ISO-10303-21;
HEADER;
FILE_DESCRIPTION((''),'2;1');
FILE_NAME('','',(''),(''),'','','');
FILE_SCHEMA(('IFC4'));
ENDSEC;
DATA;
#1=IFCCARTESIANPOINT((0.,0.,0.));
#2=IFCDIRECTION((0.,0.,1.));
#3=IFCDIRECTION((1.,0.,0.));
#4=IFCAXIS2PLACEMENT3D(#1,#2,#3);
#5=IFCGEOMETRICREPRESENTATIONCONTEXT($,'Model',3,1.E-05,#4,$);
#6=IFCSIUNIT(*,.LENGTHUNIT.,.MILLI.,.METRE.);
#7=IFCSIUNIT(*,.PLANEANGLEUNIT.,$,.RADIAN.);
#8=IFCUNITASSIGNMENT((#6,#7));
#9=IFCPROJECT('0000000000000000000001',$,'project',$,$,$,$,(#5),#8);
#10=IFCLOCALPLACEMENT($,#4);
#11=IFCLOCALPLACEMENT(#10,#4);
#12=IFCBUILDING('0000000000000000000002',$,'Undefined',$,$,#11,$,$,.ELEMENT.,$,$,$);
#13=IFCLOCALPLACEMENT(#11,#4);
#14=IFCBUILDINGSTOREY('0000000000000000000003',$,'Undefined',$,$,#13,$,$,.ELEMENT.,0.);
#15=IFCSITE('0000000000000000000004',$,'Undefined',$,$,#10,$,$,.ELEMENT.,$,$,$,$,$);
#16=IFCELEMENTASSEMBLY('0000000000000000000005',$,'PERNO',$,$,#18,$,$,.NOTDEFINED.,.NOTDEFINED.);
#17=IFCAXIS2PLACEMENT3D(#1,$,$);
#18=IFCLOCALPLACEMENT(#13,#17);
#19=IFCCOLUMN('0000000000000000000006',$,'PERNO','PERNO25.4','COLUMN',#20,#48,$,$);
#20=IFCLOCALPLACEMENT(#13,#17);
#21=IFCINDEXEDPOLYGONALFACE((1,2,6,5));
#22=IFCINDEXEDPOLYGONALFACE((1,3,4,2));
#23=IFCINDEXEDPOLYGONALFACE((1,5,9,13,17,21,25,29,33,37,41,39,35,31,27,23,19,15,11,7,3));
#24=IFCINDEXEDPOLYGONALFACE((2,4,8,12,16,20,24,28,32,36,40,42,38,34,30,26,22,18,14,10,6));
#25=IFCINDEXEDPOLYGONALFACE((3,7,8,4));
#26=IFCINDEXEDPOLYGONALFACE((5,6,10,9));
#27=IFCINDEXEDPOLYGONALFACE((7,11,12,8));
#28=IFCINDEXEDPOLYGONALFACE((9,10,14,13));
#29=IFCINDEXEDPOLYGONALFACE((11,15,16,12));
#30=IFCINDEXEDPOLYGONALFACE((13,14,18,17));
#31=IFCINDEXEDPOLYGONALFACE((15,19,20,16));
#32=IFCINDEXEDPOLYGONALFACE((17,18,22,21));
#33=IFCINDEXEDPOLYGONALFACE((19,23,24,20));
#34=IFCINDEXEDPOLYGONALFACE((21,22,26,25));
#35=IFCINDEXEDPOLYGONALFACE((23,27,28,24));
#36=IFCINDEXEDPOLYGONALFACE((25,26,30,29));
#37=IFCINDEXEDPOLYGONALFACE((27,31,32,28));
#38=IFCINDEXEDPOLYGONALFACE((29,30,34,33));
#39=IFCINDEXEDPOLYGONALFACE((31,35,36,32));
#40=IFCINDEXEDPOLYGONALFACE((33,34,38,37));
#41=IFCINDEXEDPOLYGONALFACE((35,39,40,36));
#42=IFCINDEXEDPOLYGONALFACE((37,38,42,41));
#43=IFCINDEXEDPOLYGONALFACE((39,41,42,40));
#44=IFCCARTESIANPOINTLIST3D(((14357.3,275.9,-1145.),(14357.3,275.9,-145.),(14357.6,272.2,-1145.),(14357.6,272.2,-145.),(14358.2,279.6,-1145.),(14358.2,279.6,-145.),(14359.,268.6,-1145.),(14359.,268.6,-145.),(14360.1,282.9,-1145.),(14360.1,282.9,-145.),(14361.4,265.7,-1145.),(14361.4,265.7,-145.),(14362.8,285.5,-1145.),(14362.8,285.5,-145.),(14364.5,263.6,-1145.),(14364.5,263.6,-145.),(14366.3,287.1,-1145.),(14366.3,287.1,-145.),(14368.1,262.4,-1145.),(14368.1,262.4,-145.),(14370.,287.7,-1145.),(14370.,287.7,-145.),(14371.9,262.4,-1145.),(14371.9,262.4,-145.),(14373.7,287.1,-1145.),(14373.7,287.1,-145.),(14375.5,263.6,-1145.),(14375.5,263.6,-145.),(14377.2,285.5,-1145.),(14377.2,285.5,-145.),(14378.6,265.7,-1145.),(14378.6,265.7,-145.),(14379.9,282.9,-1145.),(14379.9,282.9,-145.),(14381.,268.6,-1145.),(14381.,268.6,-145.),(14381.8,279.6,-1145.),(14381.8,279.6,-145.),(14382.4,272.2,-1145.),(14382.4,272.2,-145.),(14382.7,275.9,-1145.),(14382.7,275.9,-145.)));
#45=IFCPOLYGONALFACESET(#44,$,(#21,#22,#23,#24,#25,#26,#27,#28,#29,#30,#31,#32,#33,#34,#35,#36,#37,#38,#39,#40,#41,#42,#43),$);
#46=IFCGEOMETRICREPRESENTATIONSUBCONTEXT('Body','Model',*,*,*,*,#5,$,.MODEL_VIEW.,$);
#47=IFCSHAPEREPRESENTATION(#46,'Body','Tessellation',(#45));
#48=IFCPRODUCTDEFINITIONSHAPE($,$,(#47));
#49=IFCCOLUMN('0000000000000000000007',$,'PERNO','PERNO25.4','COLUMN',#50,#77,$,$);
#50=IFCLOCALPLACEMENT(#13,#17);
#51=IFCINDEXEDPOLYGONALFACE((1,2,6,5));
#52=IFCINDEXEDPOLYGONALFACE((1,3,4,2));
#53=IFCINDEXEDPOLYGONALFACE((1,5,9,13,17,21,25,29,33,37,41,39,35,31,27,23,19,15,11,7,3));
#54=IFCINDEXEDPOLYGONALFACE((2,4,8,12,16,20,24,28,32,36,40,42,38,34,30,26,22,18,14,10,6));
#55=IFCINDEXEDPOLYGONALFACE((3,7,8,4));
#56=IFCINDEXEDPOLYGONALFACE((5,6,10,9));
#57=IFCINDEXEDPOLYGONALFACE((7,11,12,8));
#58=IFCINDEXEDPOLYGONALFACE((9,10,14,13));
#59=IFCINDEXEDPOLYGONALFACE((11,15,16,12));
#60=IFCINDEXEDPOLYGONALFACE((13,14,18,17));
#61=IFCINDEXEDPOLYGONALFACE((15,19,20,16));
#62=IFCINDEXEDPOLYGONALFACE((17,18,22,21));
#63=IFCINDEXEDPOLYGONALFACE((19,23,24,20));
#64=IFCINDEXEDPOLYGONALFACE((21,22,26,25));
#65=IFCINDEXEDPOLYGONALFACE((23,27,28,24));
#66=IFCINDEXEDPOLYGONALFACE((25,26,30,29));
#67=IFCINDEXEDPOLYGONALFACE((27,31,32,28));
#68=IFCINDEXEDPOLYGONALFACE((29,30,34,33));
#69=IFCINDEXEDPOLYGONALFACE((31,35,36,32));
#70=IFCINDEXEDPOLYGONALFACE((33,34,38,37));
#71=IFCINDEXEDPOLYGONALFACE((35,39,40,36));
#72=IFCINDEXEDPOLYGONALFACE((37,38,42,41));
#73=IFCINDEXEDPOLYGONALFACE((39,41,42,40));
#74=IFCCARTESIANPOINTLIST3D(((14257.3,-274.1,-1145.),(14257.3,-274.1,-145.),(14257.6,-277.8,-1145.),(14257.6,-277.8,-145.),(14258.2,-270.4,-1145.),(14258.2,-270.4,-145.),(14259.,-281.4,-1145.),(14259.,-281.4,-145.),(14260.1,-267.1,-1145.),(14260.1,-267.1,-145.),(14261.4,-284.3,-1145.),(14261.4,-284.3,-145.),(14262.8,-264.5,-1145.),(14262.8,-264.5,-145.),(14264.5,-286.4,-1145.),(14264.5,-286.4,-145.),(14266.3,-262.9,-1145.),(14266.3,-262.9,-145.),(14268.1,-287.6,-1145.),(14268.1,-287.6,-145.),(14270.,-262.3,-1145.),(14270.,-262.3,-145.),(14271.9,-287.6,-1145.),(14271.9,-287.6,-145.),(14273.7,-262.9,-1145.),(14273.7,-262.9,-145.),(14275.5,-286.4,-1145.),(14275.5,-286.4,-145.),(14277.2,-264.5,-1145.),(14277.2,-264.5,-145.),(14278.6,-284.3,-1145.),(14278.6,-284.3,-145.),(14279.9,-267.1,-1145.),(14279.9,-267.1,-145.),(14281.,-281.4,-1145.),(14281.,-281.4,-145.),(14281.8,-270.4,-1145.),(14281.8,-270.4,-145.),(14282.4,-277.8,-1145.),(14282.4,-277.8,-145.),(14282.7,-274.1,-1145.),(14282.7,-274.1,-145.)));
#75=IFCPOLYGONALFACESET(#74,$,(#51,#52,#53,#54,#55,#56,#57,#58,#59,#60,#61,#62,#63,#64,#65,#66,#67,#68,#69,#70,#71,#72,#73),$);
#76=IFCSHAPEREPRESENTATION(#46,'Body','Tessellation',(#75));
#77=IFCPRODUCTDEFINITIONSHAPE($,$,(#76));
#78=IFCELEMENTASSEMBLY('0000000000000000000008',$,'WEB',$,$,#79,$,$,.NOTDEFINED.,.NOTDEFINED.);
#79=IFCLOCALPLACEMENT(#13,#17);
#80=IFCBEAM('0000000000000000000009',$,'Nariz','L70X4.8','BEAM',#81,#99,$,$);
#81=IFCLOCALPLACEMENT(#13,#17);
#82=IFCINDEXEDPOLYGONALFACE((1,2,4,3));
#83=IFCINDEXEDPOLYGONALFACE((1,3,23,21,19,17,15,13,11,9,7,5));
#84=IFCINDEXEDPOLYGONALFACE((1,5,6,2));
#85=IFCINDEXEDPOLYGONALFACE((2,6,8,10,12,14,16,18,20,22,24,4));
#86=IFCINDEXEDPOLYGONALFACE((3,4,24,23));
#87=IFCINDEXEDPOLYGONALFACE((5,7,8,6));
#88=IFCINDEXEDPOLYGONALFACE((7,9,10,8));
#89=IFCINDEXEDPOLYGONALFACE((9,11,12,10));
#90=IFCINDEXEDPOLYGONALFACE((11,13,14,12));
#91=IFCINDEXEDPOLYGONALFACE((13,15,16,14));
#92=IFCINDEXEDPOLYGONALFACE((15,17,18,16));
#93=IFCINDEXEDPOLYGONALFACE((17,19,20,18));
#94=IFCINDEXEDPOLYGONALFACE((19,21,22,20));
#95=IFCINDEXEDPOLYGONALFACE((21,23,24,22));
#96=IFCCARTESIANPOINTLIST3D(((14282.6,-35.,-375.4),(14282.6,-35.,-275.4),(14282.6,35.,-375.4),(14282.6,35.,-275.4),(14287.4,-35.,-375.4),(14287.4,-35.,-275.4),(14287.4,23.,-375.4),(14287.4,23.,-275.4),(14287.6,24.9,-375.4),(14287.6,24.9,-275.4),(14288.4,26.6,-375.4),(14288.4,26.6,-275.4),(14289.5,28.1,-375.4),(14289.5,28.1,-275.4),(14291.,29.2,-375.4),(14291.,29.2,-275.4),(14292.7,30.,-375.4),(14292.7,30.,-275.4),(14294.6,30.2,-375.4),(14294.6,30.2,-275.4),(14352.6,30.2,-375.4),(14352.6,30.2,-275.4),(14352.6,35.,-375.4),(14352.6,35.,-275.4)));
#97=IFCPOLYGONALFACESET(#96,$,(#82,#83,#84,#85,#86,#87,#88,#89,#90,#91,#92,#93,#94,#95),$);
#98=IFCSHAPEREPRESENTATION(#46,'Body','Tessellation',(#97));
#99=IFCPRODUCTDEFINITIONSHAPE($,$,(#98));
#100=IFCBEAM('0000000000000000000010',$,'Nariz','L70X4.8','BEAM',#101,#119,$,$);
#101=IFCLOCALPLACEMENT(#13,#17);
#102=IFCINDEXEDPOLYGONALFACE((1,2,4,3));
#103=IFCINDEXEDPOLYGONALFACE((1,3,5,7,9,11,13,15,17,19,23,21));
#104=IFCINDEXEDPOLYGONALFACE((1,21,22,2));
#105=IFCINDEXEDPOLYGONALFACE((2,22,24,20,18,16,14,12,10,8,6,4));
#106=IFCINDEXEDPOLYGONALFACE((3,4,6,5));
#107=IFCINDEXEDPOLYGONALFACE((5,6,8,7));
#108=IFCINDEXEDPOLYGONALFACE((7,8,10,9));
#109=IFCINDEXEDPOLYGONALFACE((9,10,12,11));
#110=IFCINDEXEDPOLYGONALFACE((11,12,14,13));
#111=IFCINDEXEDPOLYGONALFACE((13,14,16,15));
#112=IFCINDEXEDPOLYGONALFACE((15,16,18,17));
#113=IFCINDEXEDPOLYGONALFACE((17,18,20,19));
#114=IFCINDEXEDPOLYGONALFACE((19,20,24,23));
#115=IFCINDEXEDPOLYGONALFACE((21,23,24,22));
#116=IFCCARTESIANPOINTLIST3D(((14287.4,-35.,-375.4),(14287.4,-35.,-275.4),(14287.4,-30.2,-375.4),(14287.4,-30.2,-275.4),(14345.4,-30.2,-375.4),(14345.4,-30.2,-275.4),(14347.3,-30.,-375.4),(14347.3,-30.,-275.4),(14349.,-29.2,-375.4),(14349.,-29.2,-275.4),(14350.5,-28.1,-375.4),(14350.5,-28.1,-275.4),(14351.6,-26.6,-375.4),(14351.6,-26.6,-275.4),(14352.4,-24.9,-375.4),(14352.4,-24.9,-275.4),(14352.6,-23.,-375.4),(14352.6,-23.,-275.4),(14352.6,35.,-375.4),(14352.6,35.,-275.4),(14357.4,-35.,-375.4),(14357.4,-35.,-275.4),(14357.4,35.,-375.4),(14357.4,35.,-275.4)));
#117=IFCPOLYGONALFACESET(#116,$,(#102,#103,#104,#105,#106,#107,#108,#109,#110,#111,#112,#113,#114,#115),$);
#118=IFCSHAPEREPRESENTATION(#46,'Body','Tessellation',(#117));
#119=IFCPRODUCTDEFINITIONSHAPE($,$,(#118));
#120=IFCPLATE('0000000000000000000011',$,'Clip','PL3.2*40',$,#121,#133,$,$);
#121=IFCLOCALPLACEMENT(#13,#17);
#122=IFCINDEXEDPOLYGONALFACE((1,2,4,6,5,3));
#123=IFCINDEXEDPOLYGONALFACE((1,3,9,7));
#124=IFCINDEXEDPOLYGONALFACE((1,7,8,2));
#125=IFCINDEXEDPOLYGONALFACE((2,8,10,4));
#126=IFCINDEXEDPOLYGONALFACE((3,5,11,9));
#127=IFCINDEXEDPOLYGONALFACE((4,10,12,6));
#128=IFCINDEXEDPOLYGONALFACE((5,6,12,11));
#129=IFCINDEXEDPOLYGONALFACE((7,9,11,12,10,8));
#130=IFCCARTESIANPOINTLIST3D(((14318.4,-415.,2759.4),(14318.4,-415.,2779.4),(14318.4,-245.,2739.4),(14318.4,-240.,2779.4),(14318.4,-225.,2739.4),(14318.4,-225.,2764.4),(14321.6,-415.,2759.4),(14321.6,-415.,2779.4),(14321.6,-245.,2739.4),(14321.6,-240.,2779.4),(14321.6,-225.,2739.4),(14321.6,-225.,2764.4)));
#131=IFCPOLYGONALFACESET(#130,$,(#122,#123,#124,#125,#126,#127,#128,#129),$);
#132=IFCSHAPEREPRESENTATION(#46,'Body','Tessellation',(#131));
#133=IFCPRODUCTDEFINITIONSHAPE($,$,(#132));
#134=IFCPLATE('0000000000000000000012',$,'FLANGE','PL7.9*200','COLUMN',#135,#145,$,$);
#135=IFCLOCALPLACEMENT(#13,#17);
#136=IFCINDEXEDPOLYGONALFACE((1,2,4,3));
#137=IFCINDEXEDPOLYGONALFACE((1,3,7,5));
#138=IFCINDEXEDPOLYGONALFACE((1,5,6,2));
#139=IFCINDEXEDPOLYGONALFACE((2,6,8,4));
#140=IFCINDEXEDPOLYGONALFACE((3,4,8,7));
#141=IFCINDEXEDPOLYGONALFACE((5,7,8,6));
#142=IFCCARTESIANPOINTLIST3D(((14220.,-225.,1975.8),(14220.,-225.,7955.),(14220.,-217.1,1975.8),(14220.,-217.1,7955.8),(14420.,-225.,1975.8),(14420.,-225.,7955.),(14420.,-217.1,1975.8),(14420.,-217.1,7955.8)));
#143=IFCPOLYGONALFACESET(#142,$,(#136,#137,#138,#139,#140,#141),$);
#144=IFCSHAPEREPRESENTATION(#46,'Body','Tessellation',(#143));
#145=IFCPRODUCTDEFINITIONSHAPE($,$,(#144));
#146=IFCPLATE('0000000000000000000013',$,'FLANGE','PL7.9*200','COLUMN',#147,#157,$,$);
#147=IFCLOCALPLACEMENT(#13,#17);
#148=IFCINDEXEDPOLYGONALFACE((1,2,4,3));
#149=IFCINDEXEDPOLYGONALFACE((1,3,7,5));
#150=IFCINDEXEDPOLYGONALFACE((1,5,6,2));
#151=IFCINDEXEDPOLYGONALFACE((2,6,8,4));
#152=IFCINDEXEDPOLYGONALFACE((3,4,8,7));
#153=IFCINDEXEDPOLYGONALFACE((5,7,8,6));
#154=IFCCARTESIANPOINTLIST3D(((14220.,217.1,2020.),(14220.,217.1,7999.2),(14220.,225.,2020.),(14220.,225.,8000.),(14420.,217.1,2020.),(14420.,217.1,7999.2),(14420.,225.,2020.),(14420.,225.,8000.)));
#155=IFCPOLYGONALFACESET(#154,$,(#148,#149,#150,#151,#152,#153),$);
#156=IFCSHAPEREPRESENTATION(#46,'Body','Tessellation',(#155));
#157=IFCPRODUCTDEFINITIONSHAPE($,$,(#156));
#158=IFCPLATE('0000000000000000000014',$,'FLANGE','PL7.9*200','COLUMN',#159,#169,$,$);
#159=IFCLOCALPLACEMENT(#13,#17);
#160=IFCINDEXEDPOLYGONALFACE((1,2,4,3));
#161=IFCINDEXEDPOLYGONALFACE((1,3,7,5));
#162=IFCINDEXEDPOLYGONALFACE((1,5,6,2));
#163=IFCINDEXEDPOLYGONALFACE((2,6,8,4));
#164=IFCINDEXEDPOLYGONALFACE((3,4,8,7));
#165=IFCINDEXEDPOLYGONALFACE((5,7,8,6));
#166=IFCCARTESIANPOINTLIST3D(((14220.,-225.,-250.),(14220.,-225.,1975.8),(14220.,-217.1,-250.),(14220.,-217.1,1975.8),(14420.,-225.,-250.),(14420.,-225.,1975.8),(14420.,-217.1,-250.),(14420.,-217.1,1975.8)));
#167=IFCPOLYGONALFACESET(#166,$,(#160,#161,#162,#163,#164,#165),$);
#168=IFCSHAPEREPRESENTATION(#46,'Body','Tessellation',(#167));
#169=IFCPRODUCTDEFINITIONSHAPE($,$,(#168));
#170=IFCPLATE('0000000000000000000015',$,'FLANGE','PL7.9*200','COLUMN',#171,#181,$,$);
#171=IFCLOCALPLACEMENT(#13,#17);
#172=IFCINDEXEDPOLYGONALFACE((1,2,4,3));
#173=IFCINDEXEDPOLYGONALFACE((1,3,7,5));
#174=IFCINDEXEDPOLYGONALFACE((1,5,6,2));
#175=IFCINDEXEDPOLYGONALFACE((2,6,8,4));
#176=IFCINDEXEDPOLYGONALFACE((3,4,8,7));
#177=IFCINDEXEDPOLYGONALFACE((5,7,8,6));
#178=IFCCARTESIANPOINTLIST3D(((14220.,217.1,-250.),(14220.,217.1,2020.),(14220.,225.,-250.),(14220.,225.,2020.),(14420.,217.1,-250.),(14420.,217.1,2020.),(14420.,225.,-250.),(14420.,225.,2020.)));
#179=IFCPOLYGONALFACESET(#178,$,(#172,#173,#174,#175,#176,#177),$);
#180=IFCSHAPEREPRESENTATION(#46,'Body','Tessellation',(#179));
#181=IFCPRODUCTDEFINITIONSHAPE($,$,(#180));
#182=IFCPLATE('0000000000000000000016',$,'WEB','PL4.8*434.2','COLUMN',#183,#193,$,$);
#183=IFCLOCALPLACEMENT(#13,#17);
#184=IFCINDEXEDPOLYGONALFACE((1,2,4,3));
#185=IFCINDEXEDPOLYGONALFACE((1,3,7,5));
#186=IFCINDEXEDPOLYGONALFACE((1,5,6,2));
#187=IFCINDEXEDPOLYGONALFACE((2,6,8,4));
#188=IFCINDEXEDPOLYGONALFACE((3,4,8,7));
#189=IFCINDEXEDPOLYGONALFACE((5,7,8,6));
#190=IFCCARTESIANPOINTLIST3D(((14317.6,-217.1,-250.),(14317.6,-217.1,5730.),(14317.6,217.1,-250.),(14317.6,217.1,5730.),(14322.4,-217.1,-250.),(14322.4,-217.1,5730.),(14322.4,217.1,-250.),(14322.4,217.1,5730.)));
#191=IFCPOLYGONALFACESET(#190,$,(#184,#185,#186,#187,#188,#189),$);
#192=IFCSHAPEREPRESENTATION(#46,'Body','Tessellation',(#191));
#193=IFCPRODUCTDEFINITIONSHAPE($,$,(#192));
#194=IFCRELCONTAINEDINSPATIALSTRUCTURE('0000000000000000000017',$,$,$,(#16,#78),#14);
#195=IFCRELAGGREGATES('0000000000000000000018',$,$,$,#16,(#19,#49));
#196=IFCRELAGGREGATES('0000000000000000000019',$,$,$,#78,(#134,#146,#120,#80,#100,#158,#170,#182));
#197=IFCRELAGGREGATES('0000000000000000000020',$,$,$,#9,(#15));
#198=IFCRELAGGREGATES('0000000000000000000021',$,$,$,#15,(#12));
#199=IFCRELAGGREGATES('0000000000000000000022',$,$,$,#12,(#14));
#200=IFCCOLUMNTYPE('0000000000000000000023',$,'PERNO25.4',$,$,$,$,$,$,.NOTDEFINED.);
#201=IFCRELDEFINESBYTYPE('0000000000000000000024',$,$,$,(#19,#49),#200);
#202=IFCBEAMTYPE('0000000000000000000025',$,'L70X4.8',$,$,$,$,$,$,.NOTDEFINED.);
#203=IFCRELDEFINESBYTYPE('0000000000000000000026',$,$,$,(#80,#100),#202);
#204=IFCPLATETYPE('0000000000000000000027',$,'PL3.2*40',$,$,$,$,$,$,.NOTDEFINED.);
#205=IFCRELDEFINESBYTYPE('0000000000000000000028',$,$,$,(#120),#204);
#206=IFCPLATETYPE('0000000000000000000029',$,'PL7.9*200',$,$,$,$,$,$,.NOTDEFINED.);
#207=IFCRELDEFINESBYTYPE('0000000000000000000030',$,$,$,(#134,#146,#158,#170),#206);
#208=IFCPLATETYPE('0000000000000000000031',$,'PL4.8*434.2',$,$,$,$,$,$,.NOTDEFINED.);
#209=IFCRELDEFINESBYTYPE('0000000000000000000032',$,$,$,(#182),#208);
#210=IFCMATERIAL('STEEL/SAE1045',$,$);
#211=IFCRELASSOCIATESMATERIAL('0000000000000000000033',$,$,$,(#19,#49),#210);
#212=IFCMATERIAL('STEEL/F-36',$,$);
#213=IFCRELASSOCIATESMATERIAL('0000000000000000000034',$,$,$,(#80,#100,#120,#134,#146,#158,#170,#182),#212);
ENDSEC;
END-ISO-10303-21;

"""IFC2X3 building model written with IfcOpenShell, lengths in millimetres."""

from ifc_helpers import new_model, si_unit, frame, origin_with_axes, origin_2d_with_axis, place, context, subcontext, project, spatial, polyline, circle, l_section, outline, extrude, clip, halfspace, material, type_object, element, aggregate, save


model = new_model("IFC2X3")

# Units and contexts
model_context = context("Model", 3, precision=1e-05, world=origin_with_axes())
body_context = subcontext(model_context, "Body", "Model", "MODEL_VIEW")
ifc_project = project(units=[si_unit("LENGTHUNIT", "METRE", prefix="MILLI"), si_unit("PLANEANGLEUNIT", "RADIAN")], contexts=[model_context])

# Site, building, storey
site_placement = place(None, origin_with_axes())
site = spatial("IfcSite", under=ifc_project, at=site_placement, Name="Undefined", CompositionType="ELEMENT")
building_placement = place(site_placement, origin_with_axes())
building = spatial("IfcBuilding", under=site, at=building_placement, Name="Undefined", CompositionType="ELEMENT")
storey_placement = place(building_placement, origin_with_axes())
storey = spatial("IfcBuildingStorey", under=building, at=storey_placement, Name="Undefined", CompositionType="ELEMENT", Elevation=0.0)

# Element assembly, columns
assembly_1_placement = place(storey_placement, origin_with_axes())
assembly_1 = element("IfcElementAssembly", 1, at=assembly_1_placement, inside=storey, Name="PERNO", AssemblyPlace="NOTDEFINED", PredefinedType="NOTDEFINED")
ifc_material_1 = material(Name="STEEL/SAE1045")
column_type = type_object("IfcColumnType", Name="PERNO25.4", PredefinedType="NOTDEFINED")
column_1_placement = place(assembly_1_placement, frame((14370.0, 275.0, -1145.0), z_axis=(0.0, 0.0, 1.0), x_axis=(1.0, 0.0, 0.0)))
column_1 = element("IfcColumn", 2, at=column_1_placement, type_object=column_type, material=ifc_material_1, Name="PERNO", Description="PERNO25.4", ObjectType="COLUMN", context=body_context, shape_type="SweptSolid", body=[
    extrude(circle(Radius=12.7, at=origin_2d_with_axis()), frame((0.0, 0.0, 1000.0), z_axis=(0.0, 0.0, -1.0), x_axis=(0.0, 1.0, 0.0)), (0.0, 0.0, 1.0), 1000.0),
])
column_2_placement = place(assembly_1_placement, frame((14270.0, -275.0, -1145.0), z_axis=(0.0, 0.0, 1.0), x_axis=(1.0, 0.0, 0.0)))
column_2 = element("IfcColumn", 3, at=column_2_placement, type_object=column_type, material=ifc_material_1, Name="PERNO", Description="PERNO25.4", ObjectType="COLUMN", context=body_context, shape_type="SweptSolid", body=[
    extrude(circle(Radius=12.7, at=origin_2d_with_axis()), frame((0.0, 0.0, 1000.0), z_axis=(0.0, 0.0, -1.0), x_axis=(0.0, 1.0, 0.0)), (0.0, 0.0, 1.0), 1000.0),
])
aggregate(assembly_1, [column_1, column_2])

# Element assembly, beams, plates
assembly_2_placement = place(storey_placement, origin_with_axes())
assembly_2 = element("IfcElementAssembly", 4, at=assembly_2_placement, inside=storey, Name="WEB", AssemblyPlace="NOTDEFINED", PredefinedType="NOTDEFINED")
ifc_material_2 = material(Name="STEEL/F-36")
beam_type = type_object("IfcBeamType", Name="L70X4.8", PredefinedType="NOTDEFINED")
beam_1_placement = place(assembly_2_placement, frame((14317.6, 0.0, -375.4), z_axis=(0.0, -1.0, 0.0), x_axis=(0.0, 0.0, 1.0)))
beam_1 = element("IfcBeam", 5, at=beam_1_placement, type_object=beam_type, material=ifc_material_2, Name="Nariz", Description="L70X4.8", ObjectType="BEAM", context=body_context, shape_type="SweptSolid", body=[
    extrude(l_section(Depth=70.0, Width=70.0, Thickness=4.8, FilletRadius=7.2, at=origin_2d_with_axis()), frame((100.0, 0.0, 0.0), z_axis=(-1.0, 0.0, 0.0), x_axis=(0.0, -1.0, 0.0)), (0.0, 0.0, 1.0), 100.0),
])
beam_2_placement = place(assembly_2_placement, frame((14322.4, 0.0, -275.4), z_axis=(-1.0, 0.0, 0.0), x_axis=(0.0, 0.0, -1.0)))
beam_2 = element("IfcBeam", 6, at=beam_2_placement, type_object=beam_type, material=ifc_material_2, Name="Nariz", Description="L70X4.8", ObjectType="BEAM", context=body_context, shape_type="SweptSolid", body=[
    extrude(l_section(Depth=70.0, Width=70.0, Thickness=4.8, FilletRadius=7.2, at=origin_2d_with_axis()), frame((100.0, 0.0, 0.0), z_axis=(-1.0, 0.0, 0.0), x_axis=(0.0, -1.0, 0.0)), (0.0, 0.0, 1.0), 100.0),
])
plate_type_1 = type_object("IfcPlateType", Name="PL3.2*40", PredefinedType="NOTDEFINED")
plate_1_placement = place(assembly_2_placement, frame((14320.0, -225.0, 2739.4), z_axis=(1.0, 0.0, 0.0), x_axis=(0.0, -0.000007, 1.0)))
plate_1 = element("IfcPlate", 7, at=plate_1_placement, type_object=plate_type_1, material=ifc_material_2, Name="Clip", Description="PL3.2*40", context=body_context, shape_type="SweptSolid", body=[
    extrude(outline(polyline([(0.0, 0.0), (25.0, 0.0), (40.0, 15.0), (40.0, 190.0), (20.0, 190.0), (0.0, 20.0), (0.0, 0.0)])), frame((0.0, 0.0, -1.6), z_axis=(0.0, 0.0, 1.0), x_axis=(1.0, 0.0, 0.0)), (0.0, 0.0, 1.0), 3.2),
])
plate_type_2 = type_object("IfcPlateType", Name="PL7.9*200", PredefinedType="NOTDEFINED")
plate_2_placement = place(assembly_2_placement, frame((14320.0, -221.1, 1975.8), z_axis=(0.0, -1.0, 0.0), x_axis=(0.0, 0.0, 1.0)))
plate_2 = element("IfcPlate", 8, at=plate_2_placement, type_object=plate_type_2, material=ifc_material_2, Name="FLANGE", Description="PL7.9*200", ObjectType="COLUMN", context=body_context, shape_type="Clipping", body=[
    clip(extrude(outline(polyline([(0.0, -100.0), (0.0, 100.0), (5980.0, 100.0), (5980.0, -100.0), (0.0, -100.0)])), frame((0.0, 0.0, -4.0), z_axis=(0.0, 0.0, 1.0), x_axis=(1.0, 0.0, 0.0)), (0.0, 0.0, 1.0), 7.9), halfspace(frame((5979.6, 0.0, 0.0), z_axis=(-0.995037, 0.0, -0.099504), x_axis=(0.0, 1.0, 0.0)), True)),
])
plate_3_placement = place(assembly_2_placement, frame((14320.0, 221.0, 2020.0), z_axis=(0.0, -1.0, 0.0), x_axis=(0.0, 0.0, 1.0)))
plate_3 = element("IfcPlate", 9, at=plate_3_placement, type_object=plate_type_2, material=ifc_material_2, Name="FLANGE", Description="PL7.9*200", ObjectType="COLUMN", context=body_context, shape_type="Clipping", body=[
    clip(extrude(outline(polyline([(0.0, -100.0), (0.0, 100.0), (5980.0, 100.0), (5980.0, -100.0), (0.0, -100.0)])), frame((0.0, 0.0, -4.0), z_axis=(0.0, 0.0, 1.0), x_axis=(1.0, 0.0, 0.0)), (0.0, 0.0, 1.0), 7.9), halfspace(frame((5979.6, 0.0, 0.0), z_axis=(-0.995037, 0.0, -0.099504), x_axis=(0.0, -1.0, 0.0)), True)),
])
plate_4_placement = place(assembly_2_placement, frame((14320.0, -221.1, -250.0), z_axis=(0.0, -1.0, 0.0), x_axis=(0.0, 0.0, 1.0)))
plate_4 = element("IfcPlate", 10, at=plate_4_placement, type_object=plate_type_2, material=ifc_material_2, Name="FLANGE", Description="PL7.9*200", ObjectType="COLUMN", context=body_context, shape_type="SweptSolid", body=[
    extrude(outline(polyline([(0.0, -100.0), (0.0, 100.0), (2225.8, 100.0), (2225.8, -100.0), (0.0, -100.0)])), frame((0.0, 0.0, -4.0), z_axis=(0.0, 0.0, 1.0), x_axis=(1.0, 0.0, 0.0)), (0.0, 0.0, 1.0), 7.9),
])
plate_5_placement = place(assembly_2_placement, frame((14320.0, 221.0, -250.0), z_axis=(0.0, -1.0, 0.0), x_axis=(0.0, 0.0, 1.0)))
plate_5 = element("IfcPlate", 11, at=plate_5_placement, type_object=plate_type_2, material=ifc_material_2, Name="FLANGE", Description="PL7.9*200", ObjectType="COLUMN", context=body_context, shape_type="SweptSolid", body=[
    extrude(outline(polyline([(0.0, -100.0), (0.0, 100.0), (2270.0, 100.0), (2270.0, -100.0), (0.0, -100.0)])), frame((0.0, 0.0, -4.0), z_axis=(0.0, 0.0, 1.0), x_axis=(1.0, 0.0, 0.0)), (0.0, 0.0, 1.0), 7.9),
])
plate_type_3 = type_object("IfcPlateType", Name="PL4.8*434.2", PredefinedType="NOTDEFINED")
plate_6_placement = place(assembly_2_placement, frame((14320.0, 0.0, -250.0), z_axis=(1.0, 0.0, 0.0), x_axis=(0.0, 0.0, 1.0)))
plate_6 = element("IfcPlate", 12, at=plate_6_placement, type_object=plate_type_3, material=ifc_material_2, Name="WEB", Description="PL4.8*434.2", ObjectType="COLUMN", context=body_context, shape_type="SweptSolid", body=[
    extrude(outline(polyline([(0.0, -217.1), (0.0, 217.1), (5980.0, 217.1), (5980.0, -217.1), (0.0, -217.1)])), frame((0.0, 0.0, -2.4), z_axis=(0.0, 0.0, 1.0), x_axis=(1.0, 0.0, 0.0)), (0.0, 0.0, 1.0), 4.8),
])

aggregate(assembly_2, [plate_2, plate_3, plate_1, beam_1, beam_2, plate_4, plate_5, plate_6])

save(model, "model.ifc")
